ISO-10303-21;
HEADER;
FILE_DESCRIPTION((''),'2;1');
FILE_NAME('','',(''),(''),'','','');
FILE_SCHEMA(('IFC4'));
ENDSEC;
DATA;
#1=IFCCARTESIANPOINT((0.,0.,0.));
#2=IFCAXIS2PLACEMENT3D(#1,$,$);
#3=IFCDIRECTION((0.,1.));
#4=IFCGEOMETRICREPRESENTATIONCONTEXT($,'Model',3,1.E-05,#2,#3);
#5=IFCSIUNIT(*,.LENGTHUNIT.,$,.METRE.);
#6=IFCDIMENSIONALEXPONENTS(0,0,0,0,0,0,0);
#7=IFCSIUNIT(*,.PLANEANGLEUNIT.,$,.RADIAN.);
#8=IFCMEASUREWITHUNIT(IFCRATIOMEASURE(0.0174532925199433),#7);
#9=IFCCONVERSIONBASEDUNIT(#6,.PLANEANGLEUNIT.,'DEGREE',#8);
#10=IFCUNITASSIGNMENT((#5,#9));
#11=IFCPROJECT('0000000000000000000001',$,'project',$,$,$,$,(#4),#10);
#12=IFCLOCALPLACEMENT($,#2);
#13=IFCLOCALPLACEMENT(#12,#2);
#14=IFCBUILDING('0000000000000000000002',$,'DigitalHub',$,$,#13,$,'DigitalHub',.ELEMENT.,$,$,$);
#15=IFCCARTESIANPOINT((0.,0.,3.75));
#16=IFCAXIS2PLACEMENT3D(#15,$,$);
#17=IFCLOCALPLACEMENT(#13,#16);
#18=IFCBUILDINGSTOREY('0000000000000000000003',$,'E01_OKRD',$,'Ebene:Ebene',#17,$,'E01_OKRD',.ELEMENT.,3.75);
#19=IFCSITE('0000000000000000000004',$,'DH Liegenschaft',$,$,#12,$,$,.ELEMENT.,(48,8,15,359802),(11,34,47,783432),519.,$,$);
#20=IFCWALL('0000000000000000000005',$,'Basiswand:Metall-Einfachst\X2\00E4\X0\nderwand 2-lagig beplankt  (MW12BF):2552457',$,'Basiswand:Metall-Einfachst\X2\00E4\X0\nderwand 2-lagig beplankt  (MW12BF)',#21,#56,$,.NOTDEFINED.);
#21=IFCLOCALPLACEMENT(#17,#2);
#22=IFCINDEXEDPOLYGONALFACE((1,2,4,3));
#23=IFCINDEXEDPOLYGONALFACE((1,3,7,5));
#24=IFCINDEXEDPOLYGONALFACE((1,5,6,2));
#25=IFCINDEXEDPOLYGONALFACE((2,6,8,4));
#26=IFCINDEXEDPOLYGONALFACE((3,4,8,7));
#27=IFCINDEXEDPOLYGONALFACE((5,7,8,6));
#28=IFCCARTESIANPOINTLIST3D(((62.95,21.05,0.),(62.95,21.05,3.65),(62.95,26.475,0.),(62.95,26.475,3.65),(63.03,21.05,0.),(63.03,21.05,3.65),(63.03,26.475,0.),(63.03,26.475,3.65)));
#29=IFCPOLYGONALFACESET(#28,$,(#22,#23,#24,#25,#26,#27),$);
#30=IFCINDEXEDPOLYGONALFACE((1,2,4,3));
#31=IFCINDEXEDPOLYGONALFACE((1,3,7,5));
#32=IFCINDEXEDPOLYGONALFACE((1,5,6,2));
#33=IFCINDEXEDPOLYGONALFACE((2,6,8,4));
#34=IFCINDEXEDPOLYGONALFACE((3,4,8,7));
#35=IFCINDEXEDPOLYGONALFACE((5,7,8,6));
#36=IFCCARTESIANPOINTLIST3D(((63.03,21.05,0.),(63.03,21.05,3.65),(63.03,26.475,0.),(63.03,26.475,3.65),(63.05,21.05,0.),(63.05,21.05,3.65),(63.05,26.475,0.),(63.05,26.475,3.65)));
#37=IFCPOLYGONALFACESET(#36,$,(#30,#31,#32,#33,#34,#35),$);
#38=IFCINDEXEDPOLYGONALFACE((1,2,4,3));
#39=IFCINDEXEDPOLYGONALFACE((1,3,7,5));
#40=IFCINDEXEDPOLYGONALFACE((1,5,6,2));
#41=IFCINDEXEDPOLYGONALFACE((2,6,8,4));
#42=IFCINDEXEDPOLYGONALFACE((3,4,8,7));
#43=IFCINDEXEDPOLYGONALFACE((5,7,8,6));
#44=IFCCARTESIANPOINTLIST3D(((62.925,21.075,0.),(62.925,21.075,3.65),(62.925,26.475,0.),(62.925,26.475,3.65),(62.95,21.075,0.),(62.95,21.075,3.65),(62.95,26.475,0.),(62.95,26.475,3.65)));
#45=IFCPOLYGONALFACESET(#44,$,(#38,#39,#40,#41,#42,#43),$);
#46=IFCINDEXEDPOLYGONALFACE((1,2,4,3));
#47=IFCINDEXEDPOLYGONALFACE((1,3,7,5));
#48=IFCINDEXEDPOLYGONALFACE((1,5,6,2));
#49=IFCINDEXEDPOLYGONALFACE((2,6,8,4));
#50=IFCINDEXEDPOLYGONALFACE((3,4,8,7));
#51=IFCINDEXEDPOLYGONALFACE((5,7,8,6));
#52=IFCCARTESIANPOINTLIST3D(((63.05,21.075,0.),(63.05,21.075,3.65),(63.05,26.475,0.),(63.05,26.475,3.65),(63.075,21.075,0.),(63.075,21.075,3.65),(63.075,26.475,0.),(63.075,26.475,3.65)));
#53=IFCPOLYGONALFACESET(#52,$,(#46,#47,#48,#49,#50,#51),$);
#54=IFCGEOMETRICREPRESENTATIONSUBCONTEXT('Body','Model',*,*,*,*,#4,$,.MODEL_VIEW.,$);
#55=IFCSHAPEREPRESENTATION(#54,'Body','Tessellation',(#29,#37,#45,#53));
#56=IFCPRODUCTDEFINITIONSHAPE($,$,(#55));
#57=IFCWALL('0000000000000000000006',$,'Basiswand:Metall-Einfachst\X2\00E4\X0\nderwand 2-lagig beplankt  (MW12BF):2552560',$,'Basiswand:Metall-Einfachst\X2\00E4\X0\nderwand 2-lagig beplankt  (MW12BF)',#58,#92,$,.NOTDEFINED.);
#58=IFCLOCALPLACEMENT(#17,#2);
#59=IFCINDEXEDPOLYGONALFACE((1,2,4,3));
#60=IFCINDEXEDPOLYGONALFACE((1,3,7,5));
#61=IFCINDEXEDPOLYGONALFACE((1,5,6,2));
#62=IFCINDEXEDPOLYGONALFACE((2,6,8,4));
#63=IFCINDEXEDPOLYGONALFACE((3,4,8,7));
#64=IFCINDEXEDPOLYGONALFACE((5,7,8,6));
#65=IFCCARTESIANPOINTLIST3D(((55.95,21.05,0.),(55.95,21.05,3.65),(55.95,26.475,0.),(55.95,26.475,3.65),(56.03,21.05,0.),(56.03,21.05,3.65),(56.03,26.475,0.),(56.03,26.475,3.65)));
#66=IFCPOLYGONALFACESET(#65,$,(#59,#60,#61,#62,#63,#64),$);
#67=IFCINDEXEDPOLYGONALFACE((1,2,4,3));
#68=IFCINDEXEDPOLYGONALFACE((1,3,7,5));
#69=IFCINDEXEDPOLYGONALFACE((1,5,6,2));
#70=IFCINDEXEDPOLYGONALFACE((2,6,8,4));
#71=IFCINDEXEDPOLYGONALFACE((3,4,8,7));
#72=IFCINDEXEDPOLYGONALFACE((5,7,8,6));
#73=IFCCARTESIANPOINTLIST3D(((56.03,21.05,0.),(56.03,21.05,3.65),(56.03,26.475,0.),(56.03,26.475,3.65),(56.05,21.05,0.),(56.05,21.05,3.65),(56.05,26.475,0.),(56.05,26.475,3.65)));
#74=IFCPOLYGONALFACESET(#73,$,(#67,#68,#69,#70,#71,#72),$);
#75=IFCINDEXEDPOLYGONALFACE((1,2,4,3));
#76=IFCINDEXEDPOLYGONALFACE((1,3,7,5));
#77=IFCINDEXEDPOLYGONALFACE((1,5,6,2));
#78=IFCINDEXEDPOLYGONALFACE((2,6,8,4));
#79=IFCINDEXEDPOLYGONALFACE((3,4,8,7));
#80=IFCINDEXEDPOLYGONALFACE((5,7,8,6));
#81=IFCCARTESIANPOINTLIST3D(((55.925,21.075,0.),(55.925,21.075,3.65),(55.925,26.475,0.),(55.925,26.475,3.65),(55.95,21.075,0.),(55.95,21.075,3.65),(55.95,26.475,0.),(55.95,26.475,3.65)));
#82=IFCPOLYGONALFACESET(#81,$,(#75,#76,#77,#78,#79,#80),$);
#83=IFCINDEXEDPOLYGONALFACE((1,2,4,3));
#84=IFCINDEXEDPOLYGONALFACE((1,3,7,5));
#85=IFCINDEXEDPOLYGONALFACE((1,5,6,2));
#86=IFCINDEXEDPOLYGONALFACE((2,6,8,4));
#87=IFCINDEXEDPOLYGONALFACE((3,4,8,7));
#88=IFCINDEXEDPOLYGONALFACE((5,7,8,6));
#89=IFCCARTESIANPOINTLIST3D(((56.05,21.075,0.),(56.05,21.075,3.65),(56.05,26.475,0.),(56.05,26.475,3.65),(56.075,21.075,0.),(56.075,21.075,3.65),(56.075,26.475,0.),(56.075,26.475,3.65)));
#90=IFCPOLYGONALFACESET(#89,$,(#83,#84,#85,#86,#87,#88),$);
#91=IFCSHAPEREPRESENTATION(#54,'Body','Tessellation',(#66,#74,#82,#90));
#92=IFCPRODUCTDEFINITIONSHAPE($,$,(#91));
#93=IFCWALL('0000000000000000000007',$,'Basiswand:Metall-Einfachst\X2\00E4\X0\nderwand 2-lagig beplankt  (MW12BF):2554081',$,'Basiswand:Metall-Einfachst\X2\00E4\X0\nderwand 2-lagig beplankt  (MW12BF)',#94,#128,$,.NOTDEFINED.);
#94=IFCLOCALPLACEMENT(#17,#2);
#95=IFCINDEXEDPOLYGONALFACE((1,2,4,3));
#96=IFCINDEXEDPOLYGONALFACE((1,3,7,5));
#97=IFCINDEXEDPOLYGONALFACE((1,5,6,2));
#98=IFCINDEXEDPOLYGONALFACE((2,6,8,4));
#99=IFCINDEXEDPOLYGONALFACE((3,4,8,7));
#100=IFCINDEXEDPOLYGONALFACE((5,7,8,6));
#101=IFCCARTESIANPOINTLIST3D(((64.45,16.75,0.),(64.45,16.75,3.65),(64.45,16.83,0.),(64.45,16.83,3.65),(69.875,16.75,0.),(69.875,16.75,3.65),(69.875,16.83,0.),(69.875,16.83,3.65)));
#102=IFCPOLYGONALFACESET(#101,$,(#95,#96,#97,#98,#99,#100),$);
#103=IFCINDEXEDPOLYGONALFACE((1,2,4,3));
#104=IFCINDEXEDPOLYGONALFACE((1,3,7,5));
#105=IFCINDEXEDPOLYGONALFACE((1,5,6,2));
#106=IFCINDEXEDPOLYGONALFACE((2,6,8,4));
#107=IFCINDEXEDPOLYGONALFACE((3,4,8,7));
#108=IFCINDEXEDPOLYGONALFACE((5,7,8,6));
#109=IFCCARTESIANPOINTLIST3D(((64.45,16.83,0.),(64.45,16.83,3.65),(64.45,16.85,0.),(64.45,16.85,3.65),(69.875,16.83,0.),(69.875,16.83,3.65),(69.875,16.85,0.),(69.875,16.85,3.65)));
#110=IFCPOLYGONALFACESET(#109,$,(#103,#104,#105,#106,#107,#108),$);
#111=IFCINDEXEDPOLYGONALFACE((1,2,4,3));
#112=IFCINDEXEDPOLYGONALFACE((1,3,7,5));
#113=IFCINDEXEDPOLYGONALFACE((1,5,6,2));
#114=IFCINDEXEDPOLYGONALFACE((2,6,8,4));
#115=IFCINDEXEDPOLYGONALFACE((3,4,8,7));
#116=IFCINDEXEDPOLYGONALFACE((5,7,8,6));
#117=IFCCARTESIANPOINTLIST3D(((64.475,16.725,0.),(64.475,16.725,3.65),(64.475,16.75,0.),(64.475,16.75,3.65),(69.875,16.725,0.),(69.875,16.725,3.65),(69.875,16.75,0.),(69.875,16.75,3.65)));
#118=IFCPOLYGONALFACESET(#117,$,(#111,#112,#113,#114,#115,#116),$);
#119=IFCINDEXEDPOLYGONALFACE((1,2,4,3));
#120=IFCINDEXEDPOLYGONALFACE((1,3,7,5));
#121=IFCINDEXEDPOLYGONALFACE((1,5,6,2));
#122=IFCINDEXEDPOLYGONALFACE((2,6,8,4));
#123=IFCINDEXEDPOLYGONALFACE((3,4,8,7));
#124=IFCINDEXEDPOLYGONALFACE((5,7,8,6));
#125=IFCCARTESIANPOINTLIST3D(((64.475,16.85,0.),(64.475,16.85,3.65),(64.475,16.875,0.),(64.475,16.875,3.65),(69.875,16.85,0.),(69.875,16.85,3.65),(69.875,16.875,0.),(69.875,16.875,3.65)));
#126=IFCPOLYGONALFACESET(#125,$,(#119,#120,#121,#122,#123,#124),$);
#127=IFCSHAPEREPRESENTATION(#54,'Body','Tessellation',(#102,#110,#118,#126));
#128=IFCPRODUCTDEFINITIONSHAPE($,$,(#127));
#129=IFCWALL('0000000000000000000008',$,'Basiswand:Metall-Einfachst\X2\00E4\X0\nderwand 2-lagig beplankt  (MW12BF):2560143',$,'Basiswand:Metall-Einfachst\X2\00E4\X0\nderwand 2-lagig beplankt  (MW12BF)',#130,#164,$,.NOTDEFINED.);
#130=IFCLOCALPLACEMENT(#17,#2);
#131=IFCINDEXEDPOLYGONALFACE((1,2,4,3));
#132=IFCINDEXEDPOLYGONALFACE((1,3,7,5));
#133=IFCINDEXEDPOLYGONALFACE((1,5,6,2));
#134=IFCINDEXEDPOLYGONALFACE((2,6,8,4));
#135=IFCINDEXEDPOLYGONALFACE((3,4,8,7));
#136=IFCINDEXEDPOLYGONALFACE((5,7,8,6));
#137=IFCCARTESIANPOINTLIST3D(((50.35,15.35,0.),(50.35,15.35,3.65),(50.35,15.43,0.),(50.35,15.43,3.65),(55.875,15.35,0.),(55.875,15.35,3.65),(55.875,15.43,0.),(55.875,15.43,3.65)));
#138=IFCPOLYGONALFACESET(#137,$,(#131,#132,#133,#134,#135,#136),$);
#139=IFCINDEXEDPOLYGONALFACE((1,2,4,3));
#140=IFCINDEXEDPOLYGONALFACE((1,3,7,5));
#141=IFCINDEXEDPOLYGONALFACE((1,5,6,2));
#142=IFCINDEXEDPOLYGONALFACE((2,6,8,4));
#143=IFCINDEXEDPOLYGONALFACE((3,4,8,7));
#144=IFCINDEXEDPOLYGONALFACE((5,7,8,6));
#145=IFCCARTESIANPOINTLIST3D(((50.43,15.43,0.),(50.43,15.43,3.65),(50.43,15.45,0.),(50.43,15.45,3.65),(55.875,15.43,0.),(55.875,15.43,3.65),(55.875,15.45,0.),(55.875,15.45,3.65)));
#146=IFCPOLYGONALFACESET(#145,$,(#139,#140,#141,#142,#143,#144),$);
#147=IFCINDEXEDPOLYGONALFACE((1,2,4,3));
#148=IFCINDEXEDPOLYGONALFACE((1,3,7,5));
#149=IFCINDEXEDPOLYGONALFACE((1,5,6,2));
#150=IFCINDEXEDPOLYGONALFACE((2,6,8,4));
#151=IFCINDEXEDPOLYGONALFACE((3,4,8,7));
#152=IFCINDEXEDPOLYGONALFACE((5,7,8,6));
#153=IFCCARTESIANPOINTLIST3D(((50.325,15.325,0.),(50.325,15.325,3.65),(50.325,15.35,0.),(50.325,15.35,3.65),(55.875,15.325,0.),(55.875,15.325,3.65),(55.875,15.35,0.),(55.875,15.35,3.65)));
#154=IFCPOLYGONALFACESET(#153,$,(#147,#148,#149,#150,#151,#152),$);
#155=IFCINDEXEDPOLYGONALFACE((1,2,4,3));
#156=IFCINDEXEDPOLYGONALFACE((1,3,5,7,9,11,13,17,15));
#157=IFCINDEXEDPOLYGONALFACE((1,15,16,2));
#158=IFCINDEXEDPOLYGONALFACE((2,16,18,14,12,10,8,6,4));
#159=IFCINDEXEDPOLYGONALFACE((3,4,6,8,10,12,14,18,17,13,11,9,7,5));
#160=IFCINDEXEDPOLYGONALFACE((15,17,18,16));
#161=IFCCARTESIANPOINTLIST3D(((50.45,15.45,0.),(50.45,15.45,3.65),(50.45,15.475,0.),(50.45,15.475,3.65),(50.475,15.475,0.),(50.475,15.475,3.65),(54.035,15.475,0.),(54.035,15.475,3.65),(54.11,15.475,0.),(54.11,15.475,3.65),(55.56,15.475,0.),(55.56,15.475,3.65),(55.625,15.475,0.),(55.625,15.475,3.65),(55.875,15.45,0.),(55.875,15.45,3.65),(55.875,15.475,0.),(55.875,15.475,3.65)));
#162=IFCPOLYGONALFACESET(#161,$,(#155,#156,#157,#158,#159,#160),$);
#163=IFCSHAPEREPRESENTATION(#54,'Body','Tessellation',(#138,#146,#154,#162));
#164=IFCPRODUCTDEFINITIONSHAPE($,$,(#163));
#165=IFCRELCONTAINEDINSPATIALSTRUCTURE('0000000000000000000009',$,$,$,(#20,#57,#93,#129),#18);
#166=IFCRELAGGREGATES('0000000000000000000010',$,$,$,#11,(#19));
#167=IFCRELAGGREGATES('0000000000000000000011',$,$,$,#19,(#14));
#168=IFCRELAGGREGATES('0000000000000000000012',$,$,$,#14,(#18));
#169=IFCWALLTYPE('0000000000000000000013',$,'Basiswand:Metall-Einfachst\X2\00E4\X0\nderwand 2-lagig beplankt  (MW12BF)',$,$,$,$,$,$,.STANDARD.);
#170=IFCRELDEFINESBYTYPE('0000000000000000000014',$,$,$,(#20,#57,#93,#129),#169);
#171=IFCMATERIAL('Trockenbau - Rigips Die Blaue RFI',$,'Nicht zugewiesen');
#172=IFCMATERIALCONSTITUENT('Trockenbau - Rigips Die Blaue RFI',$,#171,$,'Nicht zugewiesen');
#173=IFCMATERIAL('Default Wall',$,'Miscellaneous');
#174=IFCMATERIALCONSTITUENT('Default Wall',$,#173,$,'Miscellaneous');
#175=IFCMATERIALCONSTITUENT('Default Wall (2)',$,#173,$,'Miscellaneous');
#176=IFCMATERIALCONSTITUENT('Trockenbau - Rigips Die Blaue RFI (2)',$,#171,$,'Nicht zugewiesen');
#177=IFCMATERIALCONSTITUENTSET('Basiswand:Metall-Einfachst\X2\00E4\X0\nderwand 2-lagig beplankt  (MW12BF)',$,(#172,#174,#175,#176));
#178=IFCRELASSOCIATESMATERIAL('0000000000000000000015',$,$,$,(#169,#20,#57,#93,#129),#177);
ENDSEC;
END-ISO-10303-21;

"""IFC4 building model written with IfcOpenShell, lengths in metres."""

from ifc_helpers import new_model, entity, si_unit, converted_unit, direction, frame, origin, place, context, subcontext, project, spatial, indexed_curve, outline, extrude, material, constituent, constituent_set, type_object, element, save


model = new_model("IFC4")

# Units and contexts
model_context = context("Model", 3, precision=1e-05, world=origin(), true_north=direction((0.0, 1.0)))
body_context = subcontext(model_context, "Body", "Model", "MODEL_VIEW")
ifc_project = project(units=[si_unit("LENGTHUNIT", "METRE"), converted_unit("PLANEANGLEUNIT", "DEGREE", entity("IfcRatioMeasure", 0.0174532925199433), si_unit("PLANEANGLEUNIT", "RADIAN"), dimensions=[0, 0, 0, 0, 0, 0, 0])], contexts=[model_context])

# Site, building, storey
site_placement = place(None, frame((0.0, 0.0, 0.0)))
site = spatial("IfcSite", under=ifc_project, at=site_placement, Name="DH Liegenschaft", CompositionType="ELEMENT", RefLatitude=(48, 8, 15, 359802), RefLongitude=(11, 34, 47, 783432), RefElevation=519.0)
building_placement = place(site_placement, origin())
building = spatial("IfcBuilding", under=site, at=building_placement, Name="DigitalHub", LongName="DigitalHub", CompositionType="ELEMENT")
storey_placement = place(building_placement, frame((0.0, 0.0, 3.75)))
storey = spatial("IfcBuildingStorey", under=building, at=storey_placement, Name="E01_OKRD", ObjectType="Ebene:Ebene", LongName="E01_OKRD", CompositionType="ELEMENT", Elevation=3.75)

# Shared definitions
ifc_material_1 = material(Name="Trockenbau - Rigips Die Blaue RFI", Category="Nicht zugewiesen")
ifc_constituent_1 = constituent(ifc_material_1, Name="Trockenbau - Rigips Die Blaue RFI", Category="Nicht zugewiesen")
ifc_material_2 = material(Name="Default Wall", Category="Miscellaneous")
ifc_constituent_2 = constituent(ifc_material_2, Name="Default Wall", Category="Miscellaneous")
ifc_constituent_3 = constituent(ifc_material_2, Name="Default Wall (2)", Category="Miscellaneous")
ifc_constituent_4 = constituent(ifc_material_1, Name="Trockenbau - Rigips Die Blaue RFI (2)", Category="Nicht zugewiesen")
ifc_constituent_set_1 = constituent_set(constituents=[ifc_constituent_1, ifc_constituent_2, ifc_constituent_3, ifc_constituent_4], Name="Basiswand:Metall-Einfachständerwand 2-lagig beplankt  (MW12BF)")
wall_type_1 = type_object("IfcWallType", Name="Basiswand:Metall-Einfachständerwand 2-lagig beplankt  (MW12BF)", PredefinedType="STANDARD", material=ifc_constituent_set_1)

# Walls
wall_1_placement = place(storey_placement, frame((63.0, 21.075, 0.0), z_axis=(0.0, 0.0, 1.0), x_axis=(0.0, 1.0, 0.0)))
element("IfcWall", 1, at=wall_1_placement, inside=storey, type_object=wall_type_1, material=ifc_constituent_set_1, Name="Basiswand:Metall-Einfachständerwand 2-lagig beplankt  (MW12BF):2552457", ObjectType="Basiswand:Metall-Einfachständerwand 2-lagig beplankt  (MW12BF)", PredefinedType="NOTDEFINED", context=body_context, shape_type="SweptSolid", body=[
    extrude(outline(indexed_curve([(-2.7125, -0.04), (2.7125, -0.04), (2.7125, 0.04), (-2.7125, 0.04), (-2.7125, -0.04)], self_intersect=False)), frame((2.6875, 0.01, 0.0)), (0.0, 0.0, 1.0), 3.65),
    extrude(outline(indexed_curve([(-2.7125, -0.01), (2.7125, -0.01), (2.7125, 0.01), (-2.7125, 0.01), (-2.7125, -0.01)], self_intersect=False)), frame((2.6875, -0.04, 0.0)), (0.0, 0.0, 1.0), 3.65),
    extrude(outline(indexed_curve([(-0.0125, -2.7), (0.0125, -2.7), (0.0125, 2.7), (-0.0125, 2.7), (-0.0125, -2.7)], self_intersect=False)), frame((2.7, 0.0625, 0.0), z_axis=(0.0, 0.0, 1.0), x_axis=(0.0, -1.0, 0.0)), (0.0, 0.0, 1.0), 3.65),
    extrude(outline(indexed_curve([(-0.0125, -2.7), (0.0125, -2.7), (0.0125, 2.7), (-0.0125, 2.7), (-0.0125, -2.7)], self_intersect=False)), frame((2.7, -0.0625, 0.0), z_axis=(0.0, 0.0, 1.0), x_axis=(0.0, 1.0, 0.0)), (0.0, 0.0, 1.0), 3.65),
])
wall_2_placement = place(storey_placement, frame((56.0, 21.075, 0.0), z_axis=(0.0, 0.0, 1.0), x_axis=(0.0, 1.0, 0.0)))
element("IfcWall", 2, at=wall_2_placement, inside=storey, type_object=wall_type_1, material=ifc_constituent_set_1, Name="Basiswand:Metall-Einfachständerwand 2-lagig beplankt  (MW12BF):2552560", ObjectType="Basiswand:Metall-Einfachständerwand 2-lagig beplankt  (MW12BF)", PredefinedType="NOTDEFINED", context=body_context, shape_type="SweptSolid", body=[
    extrude(outline(indexed_curve([(-2.7125, -0.04), (2.7125, -0.04), (2.7125, 0.04), (-2.7125, 0.04), (-2.7125, -0.04)], self_intersect=False)), frame((2.6875, 0.01, 0.0)), (0.0, 0.0, 1.0), 3.65),
    extrude(outline(indexed_curve([(-2.7125, -0.01), (2.7125, -0.01), (2.7125, 0.01), (-2.7125, 0.01), (-2.7125, -0.01)], self_intersect=False)), frame((2.6875, -0.04, 0.0)), (0.0, 0.0, 1.0), 3.65),
    extrude(outline(indexed_curve([(-0.0125, -2.7), (0.0125, -2.7), (0.0125, 2.7), (-0.0125, 2.7), (-0.0125, -2.7)], self_intersect=False)), frame((2.7, 0.0625, 0.0), z_axis=(0.0, 0.0, 1.0), x_axis=(0.0, -1.0, 0.0)), (0.0, 0.0, 1.0), 3.65),
    extrude(outline(indexed_curve([(-0.0125, -2.7), (0.0125, -2.7), (0.0125, 2.7), (-0.0125, 2.7), (-0.0125, -2.7)], self_intersect=False)), frame((2.7, -0.0625, 0.0), z_axis=(0.0, 0.0, 1.0), x_axis=(0.0, 1.0, 0.0)), (0.0, 0.0, 1.0), 3.65),
])
wall_3_placement = place(storey_placement, frame((69.875, 16.8, 0.0), z_axis=(0.0, 0.0, 1.0), x_axis=(-1.0, 0.0, 0.0)))
element("IfcWall", 3, at=wall_3_placement, inside=storey, type_object=wall_type_1, material=ifc_constituent_set_1, Name="Basiswand:Metall-Einfachständerwand 2-lagig beplankt  (MW12BF):2554081", ObjectType="Basiswand:Metall-Einfachständerwand 2-lagig beplankt  (MW12BF)", PredefinedType="NOTDEFINED", context=body_context, shape_type="SweptSolid", body=[
    extrude(outline(indexed_curve([(-2.7125, -0.04), (2.7125, -0.04), (2.7125, 0.04), (-2.7125, 0.04), (-2.7125, -0.04)], self_intersect=False)), frame((2.7125, 0.01, 0.0)), (0.0, 0.0, 1.0), 3.65),
    extrude(outline(indexed_curve([(-2.7125, -0.01), (2.7125, -0.01), (2.7125, 0.01), (-2.7125, 0.01), (-2.7125, -0.01)], self_intersect=False)), frame((2.7125, -0.04, 0.0)), (0.0, 0.0, 1.0), 3.65),
    extrude(outline(indexed_curve([(-0.0125, -2.7), (0.0125, -2.7), (0.0125, 2.7), (-0.0125, 2.7), (-0.0125, -2.7)], self_intersect=False)), frame((2.7, 0.0625, 0.0), z_axis=(0.0, 0.0, 1.0), x_axis=(0.0, -1.0, 0.0)), (0.0, 0.0, 1.0), 3.65),
    extrude(outline(indexed_curve([(-0.0125, -2.7), (0.0125, -2.7), (0.0125, 2.7), (-0.0125, 2.7), (-0.0125, -2.7)], self_intersect=False)), frame((2.7, -0.0625, 0.0), z_axis=(0.0, 0.0, 1.0), x_axis=(0.0, 1.0, 0.0)), (0.0, 0.0, 1.0), 3.65),
])
wall_4_placement = place(storey_placement, frame((55.875, 15.4, 0.0), z_axis=(0.0, 0.0, 1.0), x_axis=(-1.0, 0.0, 0.0)))
element("IfcWall", 4, at=wall_4_placement, inside=storey, type_object=wall_type_1, material=ifc_constituent_set_1, Name="Basiswand:Metall-Einfachständerwand 2-lagig beplankt  (MW12BF):2560143", ObjectType="Basiswand:Metall-Einfachständerwand 2-lagig beplankt  (MW12BF)", PredefinedType="NOTDEFINED", context=body_context, shape_type="SweptSolid", body=[
    extrude(outline(indexed_curve([(-2.7625, -0.04), (2.7625, -0.04), (2.7625, 0.04), (-2.7625, 0.04), (-2.7625, -0.04)], self_intersect=False)), frame((2.7625, 0.01, 0.0)), (0.0, 0.0, 1.0), 3.65),
    extrude(outline(indexed_curve([(-2.7225, -0.01), (2.7225, -0.01), (2.7225, 0.01), (-2.7225, 0.01), (-2.7225, -0.01)], self_intersect=False)), frame((2.7225, -0.04, 0.0)), (0.0, 0.0, 1.0), 3.65),
    extrude(outline(indexed_curve([(-0.0125, -2.775), (0.0125, -2.775), (0.0125, 2.775), (-0.0125, 2.775), (-0.0125, -2.775)], self_intersect=False)), frame((2.775, 0.0625, 0.0), z_axis=(0.0, 0.0, 1.0), x_axis=(0.0, -1.0, 0.0)), (0.0, 0.0, 1.0), 3.65),
    extrude(outline(indexed_curve([(-2.0189, -0.0056), (-1.9539, -0.0056), (-0.5039, -0.0056), (-0.4289, -0.0056), (3.1311, -0.0056), (3.1561, -0.0056), (3.1561, 0.0194), (-2.2689, 0.0194), (-2.2689, -0.0056), (-2.0189, -0.0056)], self_intersect=False)), frame((2.2689, -0.0694, 0.0)), (0.0, 0.0, 1.0), 3.65),
])

save(model, "model.ifc")
